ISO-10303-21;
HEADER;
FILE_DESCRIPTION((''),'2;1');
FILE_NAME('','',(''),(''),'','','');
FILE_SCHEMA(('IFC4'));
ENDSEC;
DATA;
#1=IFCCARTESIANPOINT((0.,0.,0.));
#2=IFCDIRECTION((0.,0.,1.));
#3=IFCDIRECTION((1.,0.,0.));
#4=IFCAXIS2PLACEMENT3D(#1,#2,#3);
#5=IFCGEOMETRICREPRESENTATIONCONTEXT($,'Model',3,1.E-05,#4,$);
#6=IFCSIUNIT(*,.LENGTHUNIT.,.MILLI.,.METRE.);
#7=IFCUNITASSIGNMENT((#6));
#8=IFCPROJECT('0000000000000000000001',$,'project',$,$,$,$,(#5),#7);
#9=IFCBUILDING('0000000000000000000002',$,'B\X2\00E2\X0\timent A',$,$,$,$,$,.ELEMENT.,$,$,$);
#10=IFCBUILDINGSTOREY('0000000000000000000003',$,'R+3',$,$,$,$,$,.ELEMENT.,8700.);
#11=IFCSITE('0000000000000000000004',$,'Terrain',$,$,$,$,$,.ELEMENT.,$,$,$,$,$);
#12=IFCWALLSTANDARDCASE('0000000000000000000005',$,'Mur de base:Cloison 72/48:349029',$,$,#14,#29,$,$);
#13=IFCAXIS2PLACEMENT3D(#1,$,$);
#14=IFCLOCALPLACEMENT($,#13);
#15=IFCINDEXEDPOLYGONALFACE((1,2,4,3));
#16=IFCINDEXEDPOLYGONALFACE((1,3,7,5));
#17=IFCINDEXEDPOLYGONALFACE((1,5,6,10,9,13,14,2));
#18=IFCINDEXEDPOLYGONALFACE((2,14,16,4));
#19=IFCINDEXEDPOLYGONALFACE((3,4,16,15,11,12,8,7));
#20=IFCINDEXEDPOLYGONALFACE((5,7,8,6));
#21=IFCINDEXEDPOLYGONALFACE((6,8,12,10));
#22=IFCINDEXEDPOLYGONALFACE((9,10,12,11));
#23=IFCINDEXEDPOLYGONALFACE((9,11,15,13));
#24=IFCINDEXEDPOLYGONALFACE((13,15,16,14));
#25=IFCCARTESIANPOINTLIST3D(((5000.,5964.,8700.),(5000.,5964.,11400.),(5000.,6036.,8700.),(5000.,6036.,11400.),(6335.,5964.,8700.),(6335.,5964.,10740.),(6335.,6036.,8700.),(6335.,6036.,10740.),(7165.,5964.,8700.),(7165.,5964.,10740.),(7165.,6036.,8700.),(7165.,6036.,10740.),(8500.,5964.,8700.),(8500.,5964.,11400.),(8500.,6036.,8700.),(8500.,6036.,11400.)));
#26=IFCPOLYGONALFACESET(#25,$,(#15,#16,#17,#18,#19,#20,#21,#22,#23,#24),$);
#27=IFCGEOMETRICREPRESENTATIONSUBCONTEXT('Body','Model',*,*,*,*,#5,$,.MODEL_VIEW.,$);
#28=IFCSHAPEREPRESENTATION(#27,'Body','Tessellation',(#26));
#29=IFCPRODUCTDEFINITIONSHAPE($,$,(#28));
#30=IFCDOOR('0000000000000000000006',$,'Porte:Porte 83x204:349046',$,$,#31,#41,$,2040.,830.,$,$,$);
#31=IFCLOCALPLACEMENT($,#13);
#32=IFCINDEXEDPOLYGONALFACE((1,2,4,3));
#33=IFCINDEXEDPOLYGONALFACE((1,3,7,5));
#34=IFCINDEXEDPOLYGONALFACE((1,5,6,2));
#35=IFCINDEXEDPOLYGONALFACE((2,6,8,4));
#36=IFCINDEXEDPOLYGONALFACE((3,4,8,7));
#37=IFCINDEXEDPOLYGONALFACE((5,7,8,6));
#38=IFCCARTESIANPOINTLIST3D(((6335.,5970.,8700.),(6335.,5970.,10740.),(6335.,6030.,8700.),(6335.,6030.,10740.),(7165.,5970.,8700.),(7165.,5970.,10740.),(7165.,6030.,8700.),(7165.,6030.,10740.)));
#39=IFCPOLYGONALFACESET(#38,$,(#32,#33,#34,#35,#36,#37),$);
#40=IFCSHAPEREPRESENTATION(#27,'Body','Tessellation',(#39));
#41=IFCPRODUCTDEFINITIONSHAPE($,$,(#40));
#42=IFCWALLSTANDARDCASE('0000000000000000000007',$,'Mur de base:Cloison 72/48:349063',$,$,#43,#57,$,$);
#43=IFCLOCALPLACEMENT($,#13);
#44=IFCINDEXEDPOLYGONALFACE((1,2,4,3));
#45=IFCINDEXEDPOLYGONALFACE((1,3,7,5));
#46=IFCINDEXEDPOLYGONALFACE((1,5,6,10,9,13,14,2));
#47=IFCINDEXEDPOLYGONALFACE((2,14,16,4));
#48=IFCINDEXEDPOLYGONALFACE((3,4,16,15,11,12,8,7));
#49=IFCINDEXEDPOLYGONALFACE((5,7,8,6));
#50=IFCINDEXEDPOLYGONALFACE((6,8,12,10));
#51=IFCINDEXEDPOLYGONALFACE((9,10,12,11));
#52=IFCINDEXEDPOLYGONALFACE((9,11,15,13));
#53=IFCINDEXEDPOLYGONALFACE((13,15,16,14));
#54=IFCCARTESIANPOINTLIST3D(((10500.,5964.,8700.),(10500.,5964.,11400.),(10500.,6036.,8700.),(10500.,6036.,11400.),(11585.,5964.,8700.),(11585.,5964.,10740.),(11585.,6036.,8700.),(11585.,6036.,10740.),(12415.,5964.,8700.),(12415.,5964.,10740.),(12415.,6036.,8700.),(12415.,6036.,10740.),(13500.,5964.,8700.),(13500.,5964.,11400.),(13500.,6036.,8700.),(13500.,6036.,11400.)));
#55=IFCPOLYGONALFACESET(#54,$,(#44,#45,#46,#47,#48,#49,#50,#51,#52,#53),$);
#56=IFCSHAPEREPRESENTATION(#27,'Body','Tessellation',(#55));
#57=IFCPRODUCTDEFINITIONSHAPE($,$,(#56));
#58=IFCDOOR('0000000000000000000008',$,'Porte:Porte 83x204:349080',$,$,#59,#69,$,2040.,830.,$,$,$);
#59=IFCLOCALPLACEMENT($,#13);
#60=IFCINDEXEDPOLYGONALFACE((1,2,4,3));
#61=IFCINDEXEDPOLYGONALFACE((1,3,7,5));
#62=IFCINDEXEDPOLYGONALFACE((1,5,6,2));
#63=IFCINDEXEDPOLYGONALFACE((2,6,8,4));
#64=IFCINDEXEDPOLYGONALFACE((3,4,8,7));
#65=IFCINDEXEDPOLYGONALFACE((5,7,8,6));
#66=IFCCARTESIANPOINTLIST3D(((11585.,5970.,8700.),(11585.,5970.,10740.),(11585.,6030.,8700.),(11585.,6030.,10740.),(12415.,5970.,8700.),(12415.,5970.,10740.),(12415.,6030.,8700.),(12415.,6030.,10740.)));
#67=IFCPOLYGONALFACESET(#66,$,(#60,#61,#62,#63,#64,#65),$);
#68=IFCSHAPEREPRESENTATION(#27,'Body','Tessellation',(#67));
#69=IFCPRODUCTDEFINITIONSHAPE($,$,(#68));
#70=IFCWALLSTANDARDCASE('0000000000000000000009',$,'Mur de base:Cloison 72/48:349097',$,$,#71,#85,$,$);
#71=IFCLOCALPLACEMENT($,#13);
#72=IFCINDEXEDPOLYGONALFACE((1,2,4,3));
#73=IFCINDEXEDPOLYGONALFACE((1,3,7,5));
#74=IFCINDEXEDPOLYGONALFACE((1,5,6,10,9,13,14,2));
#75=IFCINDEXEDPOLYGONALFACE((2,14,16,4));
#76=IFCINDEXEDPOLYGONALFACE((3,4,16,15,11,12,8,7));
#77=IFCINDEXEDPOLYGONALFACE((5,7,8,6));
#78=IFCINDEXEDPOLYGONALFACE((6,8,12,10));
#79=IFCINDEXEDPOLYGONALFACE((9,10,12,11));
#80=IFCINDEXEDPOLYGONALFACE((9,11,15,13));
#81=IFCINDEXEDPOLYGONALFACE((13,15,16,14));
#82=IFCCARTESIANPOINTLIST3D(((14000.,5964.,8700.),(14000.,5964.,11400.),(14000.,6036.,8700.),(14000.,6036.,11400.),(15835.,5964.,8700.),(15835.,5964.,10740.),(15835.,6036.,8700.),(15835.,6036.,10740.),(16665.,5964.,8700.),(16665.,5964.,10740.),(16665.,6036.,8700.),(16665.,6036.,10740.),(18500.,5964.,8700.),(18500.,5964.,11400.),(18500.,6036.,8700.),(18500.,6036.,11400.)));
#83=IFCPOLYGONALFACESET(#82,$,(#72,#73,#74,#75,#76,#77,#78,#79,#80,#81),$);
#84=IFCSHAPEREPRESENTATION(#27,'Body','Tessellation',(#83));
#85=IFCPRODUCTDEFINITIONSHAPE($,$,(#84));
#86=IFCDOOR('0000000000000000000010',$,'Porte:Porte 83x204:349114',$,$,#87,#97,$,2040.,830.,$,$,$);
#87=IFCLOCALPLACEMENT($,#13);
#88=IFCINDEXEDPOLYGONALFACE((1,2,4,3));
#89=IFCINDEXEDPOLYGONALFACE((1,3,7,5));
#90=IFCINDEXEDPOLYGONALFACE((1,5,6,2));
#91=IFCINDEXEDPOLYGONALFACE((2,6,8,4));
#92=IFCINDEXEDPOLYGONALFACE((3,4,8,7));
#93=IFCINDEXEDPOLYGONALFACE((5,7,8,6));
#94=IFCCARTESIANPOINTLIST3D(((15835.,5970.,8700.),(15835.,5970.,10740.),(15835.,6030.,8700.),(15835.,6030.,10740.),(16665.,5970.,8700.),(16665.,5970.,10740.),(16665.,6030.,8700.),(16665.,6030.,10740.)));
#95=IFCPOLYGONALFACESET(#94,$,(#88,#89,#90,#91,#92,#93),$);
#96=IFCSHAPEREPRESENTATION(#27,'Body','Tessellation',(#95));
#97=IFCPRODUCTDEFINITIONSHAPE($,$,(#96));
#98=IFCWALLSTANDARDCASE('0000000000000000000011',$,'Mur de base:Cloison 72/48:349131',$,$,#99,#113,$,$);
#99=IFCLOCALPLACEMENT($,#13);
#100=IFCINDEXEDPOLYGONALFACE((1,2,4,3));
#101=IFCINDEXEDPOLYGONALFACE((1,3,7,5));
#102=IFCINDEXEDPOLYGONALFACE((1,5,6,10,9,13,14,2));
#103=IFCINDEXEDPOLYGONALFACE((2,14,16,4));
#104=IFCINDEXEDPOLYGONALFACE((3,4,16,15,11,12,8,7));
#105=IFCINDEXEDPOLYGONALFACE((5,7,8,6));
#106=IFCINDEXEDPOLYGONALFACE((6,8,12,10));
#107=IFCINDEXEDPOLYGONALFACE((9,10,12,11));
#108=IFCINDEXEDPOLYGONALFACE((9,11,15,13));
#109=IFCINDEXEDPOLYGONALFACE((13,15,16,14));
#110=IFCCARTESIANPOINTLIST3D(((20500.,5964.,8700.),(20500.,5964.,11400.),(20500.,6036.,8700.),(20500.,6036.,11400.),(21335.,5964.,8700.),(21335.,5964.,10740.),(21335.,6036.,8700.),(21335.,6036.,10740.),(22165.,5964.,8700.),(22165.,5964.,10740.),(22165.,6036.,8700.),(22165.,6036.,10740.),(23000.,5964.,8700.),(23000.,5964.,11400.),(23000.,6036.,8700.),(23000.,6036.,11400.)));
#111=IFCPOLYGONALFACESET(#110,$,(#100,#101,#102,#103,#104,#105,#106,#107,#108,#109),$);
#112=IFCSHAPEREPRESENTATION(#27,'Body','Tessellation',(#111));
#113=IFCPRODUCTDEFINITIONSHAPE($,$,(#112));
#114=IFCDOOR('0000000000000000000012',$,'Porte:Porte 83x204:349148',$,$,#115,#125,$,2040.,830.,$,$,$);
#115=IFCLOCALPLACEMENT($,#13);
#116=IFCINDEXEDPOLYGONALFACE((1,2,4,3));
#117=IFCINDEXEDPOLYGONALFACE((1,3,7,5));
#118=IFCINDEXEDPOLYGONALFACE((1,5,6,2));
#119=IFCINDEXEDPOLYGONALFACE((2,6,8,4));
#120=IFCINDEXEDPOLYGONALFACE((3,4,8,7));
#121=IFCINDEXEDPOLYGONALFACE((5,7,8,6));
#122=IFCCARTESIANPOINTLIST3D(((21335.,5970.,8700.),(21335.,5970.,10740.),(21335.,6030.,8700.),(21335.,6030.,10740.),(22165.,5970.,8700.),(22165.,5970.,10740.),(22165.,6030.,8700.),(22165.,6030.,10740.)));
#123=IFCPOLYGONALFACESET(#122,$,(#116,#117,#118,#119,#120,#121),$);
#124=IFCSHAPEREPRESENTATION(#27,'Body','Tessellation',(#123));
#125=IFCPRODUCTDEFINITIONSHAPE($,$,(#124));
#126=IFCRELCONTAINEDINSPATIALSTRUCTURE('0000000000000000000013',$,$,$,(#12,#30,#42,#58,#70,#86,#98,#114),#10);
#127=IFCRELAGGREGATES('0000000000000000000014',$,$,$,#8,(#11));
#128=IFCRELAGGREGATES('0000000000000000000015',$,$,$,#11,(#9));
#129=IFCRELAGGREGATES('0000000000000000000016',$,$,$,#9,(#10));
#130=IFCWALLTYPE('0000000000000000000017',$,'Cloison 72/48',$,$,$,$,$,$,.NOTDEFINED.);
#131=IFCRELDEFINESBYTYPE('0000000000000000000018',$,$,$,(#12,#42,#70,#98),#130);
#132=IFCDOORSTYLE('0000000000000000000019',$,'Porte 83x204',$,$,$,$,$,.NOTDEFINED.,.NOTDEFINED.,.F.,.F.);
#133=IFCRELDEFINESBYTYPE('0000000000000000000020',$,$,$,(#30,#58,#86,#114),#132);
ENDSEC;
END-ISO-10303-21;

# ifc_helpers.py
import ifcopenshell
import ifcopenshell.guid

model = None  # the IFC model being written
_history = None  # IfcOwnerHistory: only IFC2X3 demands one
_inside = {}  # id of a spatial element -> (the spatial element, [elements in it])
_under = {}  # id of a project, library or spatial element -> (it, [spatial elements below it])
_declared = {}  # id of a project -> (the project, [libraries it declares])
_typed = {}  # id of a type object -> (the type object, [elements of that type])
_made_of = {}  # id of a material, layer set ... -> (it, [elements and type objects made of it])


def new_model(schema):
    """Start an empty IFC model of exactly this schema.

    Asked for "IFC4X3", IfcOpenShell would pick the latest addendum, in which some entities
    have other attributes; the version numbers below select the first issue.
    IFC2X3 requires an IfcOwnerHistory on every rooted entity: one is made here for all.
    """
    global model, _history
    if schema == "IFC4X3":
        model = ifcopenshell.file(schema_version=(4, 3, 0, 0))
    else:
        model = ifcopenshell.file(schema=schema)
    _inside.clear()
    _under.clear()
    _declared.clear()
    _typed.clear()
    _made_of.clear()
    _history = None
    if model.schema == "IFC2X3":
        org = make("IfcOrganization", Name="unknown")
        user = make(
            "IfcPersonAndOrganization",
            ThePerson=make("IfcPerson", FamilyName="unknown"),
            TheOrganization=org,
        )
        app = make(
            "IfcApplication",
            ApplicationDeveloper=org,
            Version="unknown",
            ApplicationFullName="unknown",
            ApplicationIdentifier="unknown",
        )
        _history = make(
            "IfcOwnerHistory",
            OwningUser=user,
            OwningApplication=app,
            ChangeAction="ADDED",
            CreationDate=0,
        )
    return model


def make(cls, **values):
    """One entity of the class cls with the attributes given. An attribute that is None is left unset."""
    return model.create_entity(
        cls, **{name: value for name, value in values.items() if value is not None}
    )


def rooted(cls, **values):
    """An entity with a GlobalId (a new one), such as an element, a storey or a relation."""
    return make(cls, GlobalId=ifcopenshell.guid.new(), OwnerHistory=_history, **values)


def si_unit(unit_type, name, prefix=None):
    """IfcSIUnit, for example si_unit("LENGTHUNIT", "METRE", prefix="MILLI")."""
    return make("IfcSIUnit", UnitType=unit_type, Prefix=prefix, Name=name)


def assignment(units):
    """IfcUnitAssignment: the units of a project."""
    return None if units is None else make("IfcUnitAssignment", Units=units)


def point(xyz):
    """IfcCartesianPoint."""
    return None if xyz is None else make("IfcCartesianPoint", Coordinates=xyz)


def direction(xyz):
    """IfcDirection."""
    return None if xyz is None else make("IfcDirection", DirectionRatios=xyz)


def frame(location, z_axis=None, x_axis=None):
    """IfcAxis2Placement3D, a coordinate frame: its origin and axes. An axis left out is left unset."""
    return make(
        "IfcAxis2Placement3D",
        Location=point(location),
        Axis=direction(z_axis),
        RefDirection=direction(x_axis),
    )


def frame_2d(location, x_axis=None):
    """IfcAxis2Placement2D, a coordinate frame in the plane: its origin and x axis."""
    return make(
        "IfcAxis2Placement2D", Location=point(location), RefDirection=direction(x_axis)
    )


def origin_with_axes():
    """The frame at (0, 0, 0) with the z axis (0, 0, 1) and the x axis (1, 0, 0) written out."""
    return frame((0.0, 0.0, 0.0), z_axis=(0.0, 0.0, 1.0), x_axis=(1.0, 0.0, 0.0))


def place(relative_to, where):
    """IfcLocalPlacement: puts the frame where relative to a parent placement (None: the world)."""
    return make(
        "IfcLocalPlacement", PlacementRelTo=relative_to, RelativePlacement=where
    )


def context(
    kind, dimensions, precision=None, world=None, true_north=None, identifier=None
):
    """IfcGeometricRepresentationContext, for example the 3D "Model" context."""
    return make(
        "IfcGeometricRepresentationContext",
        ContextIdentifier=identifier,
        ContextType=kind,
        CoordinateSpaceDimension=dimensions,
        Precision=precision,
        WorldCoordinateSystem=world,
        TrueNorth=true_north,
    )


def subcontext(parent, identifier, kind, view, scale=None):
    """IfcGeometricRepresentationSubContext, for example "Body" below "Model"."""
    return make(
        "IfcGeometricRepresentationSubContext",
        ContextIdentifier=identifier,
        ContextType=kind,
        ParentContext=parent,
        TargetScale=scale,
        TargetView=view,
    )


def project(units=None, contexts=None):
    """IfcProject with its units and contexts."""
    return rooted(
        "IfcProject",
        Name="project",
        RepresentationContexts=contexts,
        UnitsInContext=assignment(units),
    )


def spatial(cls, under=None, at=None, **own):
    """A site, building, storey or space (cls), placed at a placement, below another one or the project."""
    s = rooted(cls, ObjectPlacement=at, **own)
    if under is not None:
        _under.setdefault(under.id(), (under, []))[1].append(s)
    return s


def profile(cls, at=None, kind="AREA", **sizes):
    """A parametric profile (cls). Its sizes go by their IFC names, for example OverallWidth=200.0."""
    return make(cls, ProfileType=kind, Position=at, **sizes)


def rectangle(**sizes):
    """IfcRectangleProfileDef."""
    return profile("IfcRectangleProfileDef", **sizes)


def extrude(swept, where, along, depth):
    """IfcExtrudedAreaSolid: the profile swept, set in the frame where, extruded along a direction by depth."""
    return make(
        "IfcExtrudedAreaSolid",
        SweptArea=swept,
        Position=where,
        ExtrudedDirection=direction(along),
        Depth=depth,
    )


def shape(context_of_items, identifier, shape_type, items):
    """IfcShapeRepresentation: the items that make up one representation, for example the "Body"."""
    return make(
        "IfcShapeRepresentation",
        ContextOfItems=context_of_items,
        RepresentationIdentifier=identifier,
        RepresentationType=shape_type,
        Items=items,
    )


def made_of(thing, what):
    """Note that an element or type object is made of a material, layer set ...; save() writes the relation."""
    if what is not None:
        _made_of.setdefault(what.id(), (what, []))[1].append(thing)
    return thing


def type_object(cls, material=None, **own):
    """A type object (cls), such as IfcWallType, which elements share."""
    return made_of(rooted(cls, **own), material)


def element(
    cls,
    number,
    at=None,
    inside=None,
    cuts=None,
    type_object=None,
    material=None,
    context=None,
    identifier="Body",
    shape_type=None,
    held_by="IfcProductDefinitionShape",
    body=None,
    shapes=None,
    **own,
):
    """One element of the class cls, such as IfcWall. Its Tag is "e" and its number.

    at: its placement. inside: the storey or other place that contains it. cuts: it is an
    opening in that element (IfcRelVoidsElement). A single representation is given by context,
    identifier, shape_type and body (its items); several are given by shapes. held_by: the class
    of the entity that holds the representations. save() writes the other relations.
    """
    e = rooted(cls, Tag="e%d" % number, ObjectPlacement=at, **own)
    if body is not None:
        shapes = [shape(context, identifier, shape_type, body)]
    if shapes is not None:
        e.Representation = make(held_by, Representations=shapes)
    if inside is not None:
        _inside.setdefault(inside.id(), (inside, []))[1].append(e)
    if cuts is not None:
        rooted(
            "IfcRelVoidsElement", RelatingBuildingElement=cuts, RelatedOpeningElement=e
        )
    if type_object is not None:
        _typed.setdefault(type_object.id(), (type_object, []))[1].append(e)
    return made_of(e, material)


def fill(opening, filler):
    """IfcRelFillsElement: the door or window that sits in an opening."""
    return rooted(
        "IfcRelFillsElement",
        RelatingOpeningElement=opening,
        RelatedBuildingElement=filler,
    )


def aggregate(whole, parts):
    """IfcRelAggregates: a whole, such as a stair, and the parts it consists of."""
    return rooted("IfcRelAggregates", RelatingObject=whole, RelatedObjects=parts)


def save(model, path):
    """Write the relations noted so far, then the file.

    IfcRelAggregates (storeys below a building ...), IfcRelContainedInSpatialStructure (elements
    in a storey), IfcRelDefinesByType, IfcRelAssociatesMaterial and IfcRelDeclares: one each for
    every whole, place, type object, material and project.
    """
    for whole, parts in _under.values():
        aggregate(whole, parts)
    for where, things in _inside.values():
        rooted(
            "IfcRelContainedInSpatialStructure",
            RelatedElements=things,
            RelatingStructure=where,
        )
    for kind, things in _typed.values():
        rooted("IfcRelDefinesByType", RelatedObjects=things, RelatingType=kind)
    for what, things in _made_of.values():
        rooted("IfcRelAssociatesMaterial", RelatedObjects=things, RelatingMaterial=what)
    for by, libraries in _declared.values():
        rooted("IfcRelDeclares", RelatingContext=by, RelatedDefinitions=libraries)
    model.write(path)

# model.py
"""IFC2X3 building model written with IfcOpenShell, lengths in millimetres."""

from ifc_helpers import new_model, si_unit, frame, frame_2d, origin_with_axes, place, context, subcontext, project, spatial, rectangle, extrude, type_object, element, fill, save


model = new_model("IFC2X3")

# Units and contexts
model_context = context("Model", 3, precision=1e-05, world=origin_with_axes())
body_context = subcontext(model_context, "Body", "Model", "MODEL_VIEW")
ifc_project = project(units=[si_unit("LENGTHUNIT", "METRE", prefix="MILLI")], contexts=[model_context])

# Site, building, storey
site = spatial("IfcSite", under=ifc_project, Name="Terrain", CompositionType="ELEMENT")
building = spatial("IfcBuilding", under=site, Name="Bâtiment A", CompositionType="ELEMENT")
storey = spatial("IfcBuildingStorey", under=building, Name="R+3", CompositionType="ELEMENT", Elevation=8700.0)

# Walls, openings, doors
door_style = type_object("IfcDoorStyle", Name="Porte 83x204", ConstructionType="NOTDEFINED", OperationType="NOTDEFINED", ParameterTakesPrecedence=False, Sizeable=False)
wall_type_1 = type_object("IfcWallType", Name="Cloison 72/48", PredefinedType="NOTDEFINED")
wall_1_placement = place(None, origin_with_axes())
wall_1 = element("IfcWallStandardCase", 1, at=wall_1_placement, inside=storey, type_object=wall_type_1, Name="Mur de base:Cloison 72/48:349029", context=body_context, shape_type="SweptSolid", body=[
    extrude(rectangle(XDim=3500.0, YDim=72.0, at=frame_2d((6750.0, 6000.0))), frame((0.0, 0.0, 8700.0), z_axis=(0.0, 0.0, 1.0), x_axis=(1.0, 0.0, 0.0)), (0.0, 0.0, 1.0), 2700.0),
])
opening_1_placement = place(None, origin_with_axes())
opening_1 = element("IfcOpeningElement", 2, at=opening_1_placement, cuts=wall_1, context=body_context, shape_type="SweptSolid", body=[
    extrude(rectangle(XDim=830.0, YDim=192.0, at=frame_2d((6750.0, 6000.0))), frame((0.0, 0.0, 8700.0), z_axis=(0.0, 0.0, 1.0), x_axis=(1.0, 0.0, 0.0)), (0.0, 0.0, 1.0), 2040.0),
])
door_1_placement = place(None, origin_with_axes())
door_1 = element("IfcDoor", 3, at=door_1_placement, inside=storey, type_object=door_style, Name="Porte:Porte 83x204:349046", OverallHeight=2040.0, OverallWidth=830.0, context=body_context, shape_type="SweptSolid", body=[
    extrude(rectangle(XDim=830.0, YDim=60.0, at=frame_2d((6750.0, 6000.0))), frame((0.0, 0.0, 8700.0), z_axis=(0.0, 0.0, 1.0), x_axis=(1.0, 0.0, 0.0)), (0.0, 0.0, 1.0), 2040.0),
])
fill(opening_1, door_1)
wall_2_placement = place(None, origin_with_axes())
wall_2 = element("IfcWallStandardCase", 4, at=wall_2_placement, inside=storey, type_object=wall_type_1, Name="Mur de base:Cloison 72/48:349063", context=body_context, shape_type="SweptSolid", body=[
    extrude(rectangle(XDim=3000.0, YDim=72.0, at=frame_2d((12000.0, 6000.0))), frame((0.0, 0.0, 8700.0), z_axis=(0.0, 0.0, 1.0), x_axis=(1.0, 0.0, 0.0)), (0.0, 0.0, 1.0), 2700.0),
])
opening_2_placement = place(None, origin_with_axes())
opening_2 = element("IfcOpeningElement", 5, at=opening_2_placement, cuts=wall_2, context=body_context, shape_type="SweptSolid", body=[
    extrude(rectangle(XDim=830.0, YDim=192.0, at=frame_2d((12000.0, 6000.0))), frame((0.0, 0.0, 8700.0), z_axis=(0.0, 0.0, 1.0), x_axis=(1.0, 0.0, 0.0)), (0.0, 0.0, 1.0), 2040.0),
])
door_2_placement = place(None, origin_with_axes())
door_2 = element("IfcDoor", 6, at=door_2_placement, inside=storey, type_object=door_style, Name="Porte:Porte 83x204:349080", OverallHeight=2040.0, OverallWidth=830.0, context=body_context, shape_type="SweptSolid", body=[
    extrude(rectangle(XDim=830.0, YDim=60.0, at=frame_2d((12000.0, 6000.0))), frame((0.0, 0.0, 8700.0), z_axis=(0.0, 0.0, 1.0), x_axis=(1.0, 0.0, 0.0)), (0.0, 0.0, 1.0), 2040.0),
])
fill(opening_2, door_2)
wall_3_placement = place(None, origin_with_axes())
wall_3 = element("IfcWallStandardCase", 7, at=wall_3_placement, inside=storey, type_object=wall_type_1, Name="Mur de base:Cloison 72/48:349097", context=body_context, shape_type="SweptSolid", body=[
    extrude(rectangle(XDim=4500.0, YDim=72.0, at=frame_2d((16250.0, 6000.0))), frame((0.0, 0.0, 8700.0), z_axis=(0.0, 0.0, 1.0), x_axis=(1.0, 0.0, 0.0)), (0.0, 0.0, 1.0), 2700.0),
])
opening_3_placement = place(None, origin_with_axes())
opening_3 = element("IfcOpeningElement", 8, at=opening_3_placement, cuts=wall_3, context=body_context, shape_type="SweptSolid", body=[
    extrude(rectangle(XDim=830.0, YDim=192.0, at=frame_2d((16250.0, 6000.0))), frame((0.0, 0.0, 8700.0), z_axis=(0.0, 0.0, 1.0), x_axis=(1.0, 0.0, 0.0)), (0.0, 0.0, 1.0), 2040.0),
])
door_3_placement = place(None, origin_with_axes())
door_3 = element("IfcDoor", 9, at=door_3_placement, inside=storey, type_object=door_style, Name="Porte:Porte 83x204:349114", OverallHeight=2040.0, OverallWidth=830.0, context=body_context, shape_type="SweptSolid", body=[
    extrude(rectangle(XDim=830.0, YDim=60.0, at=frame_2d((16250.0, 6000.0))), frame((0.0, 0.0, 8700.0), z_axis=(0.0, 0.0, 1.0), x_axis=(1.0, 0.0, 0.0)), (0.0, 0.0, 1.0), 2040.0),
])
fill(opening_3, door_3)
wall_4_placement = place(None, origin_with_axes())
wall_4 = element("IfcWallStandardCase", 10, at=wall_4_placement, inside=storey, type_object=wall_type_1, Name="Mur de base:Cloison 72/48:349131", context=body_context, shape_type="SweptSolid", body=[
    extrude(rectangle(XDim=2500.0, YDim=72.0, at=frame_2d((21750.0, 6000.0))), frame((0.0, 0.0, 8700.0), z_axis=(0.0, 0.0, 1.0), x_axis=(1.0, 0.0, 0.0)), (0.0, 0.0, 1.0), 2700.0),
])
opening_4_placement = place(None, origin_with_axes())
opening_4 = element("IfcOpeningElement", 11, at=opening_4_placement, cuts=wall_4, context=body_context, shape_type="SweptSolid", body=[
    extrude(rectangle(XDim=830.0, YDim=192.0, at=frame_2d((21750.0, 6000.0))), frame((0.0, 0.0, 8700.0), z_axis=(0.0, 0.0, 1.0), x_axis=(1.0, 0.0, 0.0)), (0.0, 0.0, 1.0), 2040.0),
])
door_4_placement = place(None, origin_with_axes())
door_4 = element("IfcDoor", 12, at=door_4_placement, inside=storey, type_object=door_style, Name="Porte:Porte 83x204:349148", OverallHeight=2040.0, OverallWidth=830.0, context=body_context, shape_type="SweptSolid", body=[
    extrude(rectangle(XDim=830.0, YDim=60.0, at=frame_2d((21750.0, 6000.0))), frame((0.0, 0.0, 8700.0), z_axis=(0.0, 0.0, 1.0), x_axis=(1.0, 0.0, 0.0)), (0.0, 0.0, 1.0), 2040.0),
])
fill(opening_4, door_4)

save(model, "model.ifc")
